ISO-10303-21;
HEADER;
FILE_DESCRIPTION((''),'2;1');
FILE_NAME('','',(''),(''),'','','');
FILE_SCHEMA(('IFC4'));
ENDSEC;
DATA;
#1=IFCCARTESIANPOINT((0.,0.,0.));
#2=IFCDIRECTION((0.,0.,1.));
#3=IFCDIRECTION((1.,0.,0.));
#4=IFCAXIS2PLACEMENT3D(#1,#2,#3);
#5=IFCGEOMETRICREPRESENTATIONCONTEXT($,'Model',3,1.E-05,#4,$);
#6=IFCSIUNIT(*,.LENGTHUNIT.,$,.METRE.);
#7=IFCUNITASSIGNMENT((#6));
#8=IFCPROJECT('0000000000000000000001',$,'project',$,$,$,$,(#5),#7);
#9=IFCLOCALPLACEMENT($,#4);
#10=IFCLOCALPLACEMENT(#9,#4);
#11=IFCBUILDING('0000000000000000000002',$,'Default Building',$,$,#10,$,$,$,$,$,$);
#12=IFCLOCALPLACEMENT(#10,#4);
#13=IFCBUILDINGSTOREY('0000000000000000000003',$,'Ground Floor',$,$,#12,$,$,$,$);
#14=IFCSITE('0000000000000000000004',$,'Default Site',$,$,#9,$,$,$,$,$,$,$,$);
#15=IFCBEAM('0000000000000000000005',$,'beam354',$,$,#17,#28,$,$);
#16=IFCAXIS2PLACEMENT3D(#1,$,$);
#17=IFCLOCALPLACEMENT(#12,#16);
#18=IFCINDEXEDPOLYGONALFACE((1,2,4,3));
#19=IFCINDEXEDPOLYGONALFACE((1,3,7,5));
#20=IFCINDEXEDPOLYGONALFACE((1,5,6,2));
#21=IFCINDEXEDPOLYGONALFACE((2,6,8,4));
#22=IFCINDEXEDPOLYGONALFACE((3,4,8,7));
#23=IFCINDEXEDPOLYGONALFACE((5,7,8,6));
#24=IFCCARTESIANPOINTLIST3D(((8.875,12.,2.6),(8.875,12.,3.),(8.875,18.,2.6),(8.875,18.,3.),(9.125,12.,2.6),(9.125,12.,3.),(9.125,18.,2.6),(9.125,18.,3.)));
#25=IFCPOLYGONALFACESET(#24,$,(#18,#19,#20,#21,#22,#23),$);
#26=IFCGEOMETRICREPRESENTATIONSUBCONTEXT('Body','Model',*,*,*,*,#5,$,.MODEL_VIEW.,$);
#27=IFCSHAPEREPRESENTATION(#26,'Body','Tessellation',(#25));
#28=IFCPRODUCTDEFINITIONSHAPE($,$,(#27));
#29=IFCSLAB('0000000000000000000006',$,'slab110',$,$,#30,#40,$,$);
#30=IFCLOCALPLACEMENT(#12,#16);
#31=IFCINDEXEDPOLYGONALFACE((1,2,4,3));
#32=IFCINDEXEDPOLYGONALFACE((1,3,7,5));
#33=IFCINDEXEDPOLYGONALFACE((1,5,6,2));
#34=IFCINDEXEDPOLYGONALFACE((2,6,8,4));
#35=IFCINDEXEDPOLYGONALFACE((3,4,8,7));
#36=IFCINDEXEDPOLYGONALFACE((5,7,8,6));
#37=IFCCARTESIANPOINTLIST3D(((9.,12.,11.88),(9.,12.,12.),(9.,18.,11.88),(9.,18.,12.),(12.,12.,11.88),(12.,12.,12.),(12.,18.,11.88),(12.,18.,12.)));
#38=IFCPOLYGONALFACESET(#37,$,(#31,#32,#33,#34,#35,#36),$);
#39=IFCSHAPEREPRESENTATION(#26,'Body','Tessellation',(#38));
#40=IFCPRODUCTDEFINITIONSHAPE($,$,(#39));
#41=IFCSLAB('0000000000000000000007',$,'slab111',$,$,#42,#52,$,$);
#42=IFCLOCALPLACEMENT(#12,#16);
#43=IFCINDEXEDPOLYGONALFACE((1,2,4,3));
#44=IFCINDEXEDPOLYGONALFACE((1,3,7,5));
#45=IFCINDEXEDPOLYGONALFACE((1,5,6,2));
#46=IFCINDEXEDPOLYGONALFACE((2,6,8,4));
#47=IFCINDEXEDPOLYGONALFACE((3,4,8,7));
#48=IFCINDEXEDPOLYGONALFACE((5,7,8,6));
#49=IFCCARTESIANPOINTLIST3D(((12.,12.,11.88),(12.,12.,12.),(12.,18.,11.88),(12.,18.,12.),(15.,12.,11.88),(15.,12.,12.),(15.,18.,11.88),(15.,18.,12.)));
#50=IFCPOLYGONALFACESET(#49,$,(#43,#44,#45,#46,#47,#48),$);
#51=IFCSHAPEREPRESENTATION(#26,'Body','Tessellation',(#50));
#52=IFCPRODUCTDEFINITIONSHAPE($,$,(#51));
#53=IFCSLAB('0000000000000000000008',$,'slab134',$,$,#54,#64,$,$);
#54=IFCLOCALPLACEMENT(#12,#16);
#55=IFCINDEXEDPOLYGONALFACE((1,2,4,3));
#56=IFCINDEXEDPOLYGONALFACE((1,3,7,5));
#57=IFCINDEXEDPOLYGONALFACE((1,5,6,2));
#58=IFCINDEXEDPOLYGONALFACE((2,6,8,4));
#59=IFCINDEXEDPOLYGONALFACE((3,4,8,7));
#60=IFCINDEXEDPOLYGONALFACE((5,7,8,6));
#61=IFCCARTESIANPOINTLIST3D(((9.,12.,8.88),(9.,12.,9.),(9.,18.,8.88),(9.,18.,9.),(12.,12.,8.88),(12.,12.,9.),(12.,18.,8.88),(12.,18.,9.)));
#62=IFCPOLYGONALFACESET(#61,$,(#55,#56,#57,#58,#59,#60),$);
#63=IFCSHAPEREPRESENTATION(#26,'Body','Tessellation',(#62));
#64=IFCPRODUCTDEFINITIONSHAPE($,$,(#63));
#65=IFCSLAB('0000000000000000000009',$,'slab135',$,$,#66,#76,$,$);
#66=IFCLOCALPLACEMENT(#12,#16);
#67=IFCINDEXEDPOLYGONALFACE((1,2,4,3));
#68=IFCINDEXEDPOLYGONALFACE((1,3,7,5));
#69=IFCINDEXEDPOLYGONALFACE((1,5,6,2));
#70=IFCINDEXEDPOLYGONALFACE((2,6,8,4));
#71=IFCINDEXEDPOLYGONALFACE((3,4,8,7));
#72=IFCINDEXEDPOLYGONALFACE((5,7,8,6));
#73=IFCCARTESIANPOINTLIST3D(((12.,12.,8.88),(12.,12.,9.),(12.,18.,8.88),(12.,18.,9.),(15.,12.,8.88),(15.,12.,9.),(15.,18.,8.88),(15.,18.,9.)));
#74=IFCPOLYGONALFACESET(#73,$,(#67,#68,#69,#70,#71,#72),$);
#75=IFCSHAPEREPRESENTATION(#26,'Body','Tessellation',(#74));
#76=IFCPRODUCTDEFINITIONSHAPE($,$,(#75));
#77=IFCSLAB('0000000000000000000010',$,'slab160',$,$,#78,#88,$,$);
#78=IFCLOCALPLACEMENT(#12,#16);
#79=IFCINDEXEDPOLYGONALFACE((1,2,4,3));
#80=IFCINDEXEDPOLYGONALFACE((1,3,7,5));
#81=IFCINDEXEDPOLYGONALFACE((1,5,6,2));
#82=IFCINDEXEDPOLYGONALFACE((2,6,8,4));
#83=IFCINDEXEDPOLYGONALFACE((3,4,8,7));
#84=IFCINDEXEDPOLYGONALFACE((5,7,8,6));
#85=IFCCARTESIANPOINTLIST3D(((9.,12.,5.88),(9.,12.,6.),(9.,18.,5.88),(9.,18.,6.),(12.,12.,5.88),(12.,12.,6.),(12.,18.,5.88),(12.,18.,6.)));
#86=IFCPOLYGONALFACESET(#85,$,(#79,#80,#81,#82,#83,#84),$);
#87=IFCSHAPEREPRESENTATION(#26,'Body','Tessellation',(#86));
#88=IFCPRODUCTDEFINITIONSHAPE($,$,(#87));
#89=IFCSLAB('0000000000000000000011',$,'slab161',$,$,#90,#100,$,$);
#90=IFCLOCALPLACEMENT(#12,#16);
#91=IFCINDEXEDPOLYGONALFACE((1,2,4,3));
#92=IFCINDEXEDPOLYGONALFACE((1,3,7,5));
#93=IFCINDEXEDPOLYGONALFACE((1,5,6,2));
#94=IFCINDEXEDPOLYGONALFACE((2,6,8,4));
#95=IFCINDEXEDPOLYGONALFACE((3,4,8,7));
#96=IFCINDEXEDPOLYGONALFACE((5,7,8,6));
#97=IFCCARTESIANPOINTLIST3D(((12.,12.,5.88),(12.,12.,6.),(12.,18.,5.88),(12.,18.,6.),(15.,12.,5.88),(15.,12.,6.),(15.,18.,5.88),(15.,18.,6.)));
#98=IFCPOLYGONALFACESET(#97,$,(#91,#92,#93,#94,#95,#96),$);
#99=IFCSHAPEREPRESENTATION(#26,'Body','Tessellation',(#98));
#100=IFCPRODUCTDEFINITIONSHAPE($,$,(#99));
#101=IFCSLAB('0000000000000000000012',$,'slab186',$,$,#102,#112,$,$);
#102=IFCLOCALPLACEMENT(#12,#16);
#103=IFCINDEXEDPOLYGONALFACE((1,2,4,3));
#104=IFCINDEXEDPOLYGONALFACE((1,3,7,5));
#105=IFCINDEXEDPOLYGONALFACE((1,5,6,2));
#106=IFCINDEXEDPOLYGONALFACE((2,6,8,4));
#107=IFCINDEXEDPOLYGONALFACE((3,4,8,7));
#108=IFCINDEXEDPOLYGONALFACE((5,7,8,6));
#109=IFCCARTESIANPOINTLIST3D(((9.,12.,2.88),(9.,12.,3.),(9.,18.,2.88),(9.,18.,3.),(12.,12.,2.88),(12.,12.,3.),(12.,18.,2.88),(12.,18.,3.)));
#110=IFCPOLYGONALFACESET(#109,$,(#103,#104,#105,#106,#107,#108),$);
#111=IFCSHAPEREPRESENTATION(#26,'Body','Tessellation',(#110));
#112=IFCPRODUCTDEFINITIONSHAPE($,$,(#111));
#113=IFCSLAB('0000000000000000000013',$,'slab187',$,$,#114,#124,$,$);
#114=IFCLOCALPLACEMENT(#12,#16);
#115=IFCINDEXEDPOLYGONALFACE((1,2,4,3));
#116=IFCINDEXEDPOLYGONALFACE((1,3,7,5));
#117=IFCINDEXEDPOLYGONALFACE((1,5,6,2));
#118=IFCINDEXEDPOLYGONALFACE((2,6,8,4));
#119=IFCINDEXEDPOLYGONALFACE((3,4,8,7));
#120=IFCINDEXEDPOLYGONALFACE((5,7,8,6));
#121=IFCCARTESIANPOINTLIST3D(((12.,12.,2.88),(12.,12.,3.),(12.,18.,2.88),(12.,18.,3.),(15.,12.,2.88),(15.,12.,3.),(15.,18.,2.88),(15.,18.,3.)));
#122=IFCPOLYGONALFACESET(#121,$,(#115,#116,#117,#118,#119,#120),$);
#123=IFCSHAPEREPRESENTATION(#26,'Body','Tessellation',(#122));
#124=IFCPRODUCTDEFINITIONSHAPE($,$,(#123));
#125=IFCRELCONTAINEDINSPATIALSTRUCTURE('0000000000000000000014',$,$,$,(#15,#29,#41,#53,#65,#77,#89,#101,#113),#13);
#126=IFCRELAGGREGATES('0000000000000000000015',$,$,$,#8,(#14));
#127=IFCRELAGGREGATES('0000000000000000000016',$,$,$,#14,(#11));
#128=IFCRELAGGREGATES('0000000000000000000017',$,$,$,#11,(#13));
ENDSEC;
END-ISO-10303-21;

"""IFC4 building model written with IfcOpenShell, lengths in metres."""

from ifc_helpers import new_model, si_unit, frame, origin_with_axes, place, context, subcontext, project, spatial, indexed_curve, outline, extrude, element, save


model = new_model("IFC4")

# Units and contexts
model_context = context("Model", 3, precision=1e-05, world=origin_with_axes())
body_context = subcontext(model_context, "Body", "Model", "MODEL_VIEW")
ifc_project = project(units=[si_unit("LENGTHUNIT", "METRE")], contexts=[model_context])

# Site, building, storey
site_placement = place(None, origin_with_axes())
site = spatial("IfcSite", under=ifc_project, at=site_placement, Name="Default Site")
building_placement = place(site_placement, origin_with_axes())
building = spatial("IfcBuilding", under=site, at=building_placement, Name="Default Building")
storey_placement = place(building_placement, origin_with_axes())
storey = spatial("IfcBuildingStorey", under=building, at=storey_placement, Name="Ground Floor")

# Beam
beam_1_placement = place(storey_placement, frame((8.875, 18.0, 2.6), z_axis=(0.0, 0.0, 1.0), x_axis=(0.0, -1.0, 0.0)))
element("IfcBeam", 1, at=beam_1_placement, inside=storey, Name="beam354", context=body_context, shape_type="SweptSolid", body=[
    extrude(outline(indexed_curve([(0.0, 0.0), (0.0, 0.25), (6.0, 0.25), (6.0, 0.0), (0.0, 0.0)], self_intersect=False)), origin_with_axes(), (0.0, 0.0, 1.0), 0.4),
])

# Slabs
for number, where, z_axis, x_axis, name in (
    (2, (9.0, 12.0, 11.88), (0.0, 0.0, 1.0), (1.0, 0.0, 0.0), "slab110"),
    (3, (12.0, 12.0, 11.88), (0.0, 0.0, 1.0), (1.0, 0.0, 0.0), "slab111"),
    (4, (9.0, 12.0, 8.88), (0.0, 0.0, 1.0), (1.0, 0.0, 0.0), "slab134"),
    (5, (12.0, 12.0, 8.88), (0.0, 0.0, 1.0), (1.0, 0.0, 0.0), "slab135"),
    (6, (9.0, 12.0, 5.88), (0.0, 0.0, 1.0), (1.0, 0.0, 0.0), "slab160"),
    (7, (12.0, 12.0, 5.88), (0.0, 0.0, 1.0), (1.0, 0.0, 0.0), "slab161"),
    (8, (9.0, 12.0, 2.88), (0.0, 0.0, 1.0), (1.0, 0.0, 0.0), "slab186"),
    (9, (12.0, 12.0, 2.88), (0.0, 0.0, 1.0), (1.0, 0.0, 0.0), "slab187"),
):
    element("IfcSlab", number, at=place(storey_placement, frame(where, z_axis=z_axis, x_axis=x_axis)), inside=storey, Name=name, context=body_context, shape_type="SweptSolid", body=[
        extrude(outline(indexed_curve([(0.0, 0.0), (0.0, 6.0), (3.0, 6.0), (3.0, 0.0), (0.0, 0.0)], self_intersect=False)), origin_with_axes(), (0.0, 0.0, 1.0), 0.12),
    ])

save(model, "model.ifc")
